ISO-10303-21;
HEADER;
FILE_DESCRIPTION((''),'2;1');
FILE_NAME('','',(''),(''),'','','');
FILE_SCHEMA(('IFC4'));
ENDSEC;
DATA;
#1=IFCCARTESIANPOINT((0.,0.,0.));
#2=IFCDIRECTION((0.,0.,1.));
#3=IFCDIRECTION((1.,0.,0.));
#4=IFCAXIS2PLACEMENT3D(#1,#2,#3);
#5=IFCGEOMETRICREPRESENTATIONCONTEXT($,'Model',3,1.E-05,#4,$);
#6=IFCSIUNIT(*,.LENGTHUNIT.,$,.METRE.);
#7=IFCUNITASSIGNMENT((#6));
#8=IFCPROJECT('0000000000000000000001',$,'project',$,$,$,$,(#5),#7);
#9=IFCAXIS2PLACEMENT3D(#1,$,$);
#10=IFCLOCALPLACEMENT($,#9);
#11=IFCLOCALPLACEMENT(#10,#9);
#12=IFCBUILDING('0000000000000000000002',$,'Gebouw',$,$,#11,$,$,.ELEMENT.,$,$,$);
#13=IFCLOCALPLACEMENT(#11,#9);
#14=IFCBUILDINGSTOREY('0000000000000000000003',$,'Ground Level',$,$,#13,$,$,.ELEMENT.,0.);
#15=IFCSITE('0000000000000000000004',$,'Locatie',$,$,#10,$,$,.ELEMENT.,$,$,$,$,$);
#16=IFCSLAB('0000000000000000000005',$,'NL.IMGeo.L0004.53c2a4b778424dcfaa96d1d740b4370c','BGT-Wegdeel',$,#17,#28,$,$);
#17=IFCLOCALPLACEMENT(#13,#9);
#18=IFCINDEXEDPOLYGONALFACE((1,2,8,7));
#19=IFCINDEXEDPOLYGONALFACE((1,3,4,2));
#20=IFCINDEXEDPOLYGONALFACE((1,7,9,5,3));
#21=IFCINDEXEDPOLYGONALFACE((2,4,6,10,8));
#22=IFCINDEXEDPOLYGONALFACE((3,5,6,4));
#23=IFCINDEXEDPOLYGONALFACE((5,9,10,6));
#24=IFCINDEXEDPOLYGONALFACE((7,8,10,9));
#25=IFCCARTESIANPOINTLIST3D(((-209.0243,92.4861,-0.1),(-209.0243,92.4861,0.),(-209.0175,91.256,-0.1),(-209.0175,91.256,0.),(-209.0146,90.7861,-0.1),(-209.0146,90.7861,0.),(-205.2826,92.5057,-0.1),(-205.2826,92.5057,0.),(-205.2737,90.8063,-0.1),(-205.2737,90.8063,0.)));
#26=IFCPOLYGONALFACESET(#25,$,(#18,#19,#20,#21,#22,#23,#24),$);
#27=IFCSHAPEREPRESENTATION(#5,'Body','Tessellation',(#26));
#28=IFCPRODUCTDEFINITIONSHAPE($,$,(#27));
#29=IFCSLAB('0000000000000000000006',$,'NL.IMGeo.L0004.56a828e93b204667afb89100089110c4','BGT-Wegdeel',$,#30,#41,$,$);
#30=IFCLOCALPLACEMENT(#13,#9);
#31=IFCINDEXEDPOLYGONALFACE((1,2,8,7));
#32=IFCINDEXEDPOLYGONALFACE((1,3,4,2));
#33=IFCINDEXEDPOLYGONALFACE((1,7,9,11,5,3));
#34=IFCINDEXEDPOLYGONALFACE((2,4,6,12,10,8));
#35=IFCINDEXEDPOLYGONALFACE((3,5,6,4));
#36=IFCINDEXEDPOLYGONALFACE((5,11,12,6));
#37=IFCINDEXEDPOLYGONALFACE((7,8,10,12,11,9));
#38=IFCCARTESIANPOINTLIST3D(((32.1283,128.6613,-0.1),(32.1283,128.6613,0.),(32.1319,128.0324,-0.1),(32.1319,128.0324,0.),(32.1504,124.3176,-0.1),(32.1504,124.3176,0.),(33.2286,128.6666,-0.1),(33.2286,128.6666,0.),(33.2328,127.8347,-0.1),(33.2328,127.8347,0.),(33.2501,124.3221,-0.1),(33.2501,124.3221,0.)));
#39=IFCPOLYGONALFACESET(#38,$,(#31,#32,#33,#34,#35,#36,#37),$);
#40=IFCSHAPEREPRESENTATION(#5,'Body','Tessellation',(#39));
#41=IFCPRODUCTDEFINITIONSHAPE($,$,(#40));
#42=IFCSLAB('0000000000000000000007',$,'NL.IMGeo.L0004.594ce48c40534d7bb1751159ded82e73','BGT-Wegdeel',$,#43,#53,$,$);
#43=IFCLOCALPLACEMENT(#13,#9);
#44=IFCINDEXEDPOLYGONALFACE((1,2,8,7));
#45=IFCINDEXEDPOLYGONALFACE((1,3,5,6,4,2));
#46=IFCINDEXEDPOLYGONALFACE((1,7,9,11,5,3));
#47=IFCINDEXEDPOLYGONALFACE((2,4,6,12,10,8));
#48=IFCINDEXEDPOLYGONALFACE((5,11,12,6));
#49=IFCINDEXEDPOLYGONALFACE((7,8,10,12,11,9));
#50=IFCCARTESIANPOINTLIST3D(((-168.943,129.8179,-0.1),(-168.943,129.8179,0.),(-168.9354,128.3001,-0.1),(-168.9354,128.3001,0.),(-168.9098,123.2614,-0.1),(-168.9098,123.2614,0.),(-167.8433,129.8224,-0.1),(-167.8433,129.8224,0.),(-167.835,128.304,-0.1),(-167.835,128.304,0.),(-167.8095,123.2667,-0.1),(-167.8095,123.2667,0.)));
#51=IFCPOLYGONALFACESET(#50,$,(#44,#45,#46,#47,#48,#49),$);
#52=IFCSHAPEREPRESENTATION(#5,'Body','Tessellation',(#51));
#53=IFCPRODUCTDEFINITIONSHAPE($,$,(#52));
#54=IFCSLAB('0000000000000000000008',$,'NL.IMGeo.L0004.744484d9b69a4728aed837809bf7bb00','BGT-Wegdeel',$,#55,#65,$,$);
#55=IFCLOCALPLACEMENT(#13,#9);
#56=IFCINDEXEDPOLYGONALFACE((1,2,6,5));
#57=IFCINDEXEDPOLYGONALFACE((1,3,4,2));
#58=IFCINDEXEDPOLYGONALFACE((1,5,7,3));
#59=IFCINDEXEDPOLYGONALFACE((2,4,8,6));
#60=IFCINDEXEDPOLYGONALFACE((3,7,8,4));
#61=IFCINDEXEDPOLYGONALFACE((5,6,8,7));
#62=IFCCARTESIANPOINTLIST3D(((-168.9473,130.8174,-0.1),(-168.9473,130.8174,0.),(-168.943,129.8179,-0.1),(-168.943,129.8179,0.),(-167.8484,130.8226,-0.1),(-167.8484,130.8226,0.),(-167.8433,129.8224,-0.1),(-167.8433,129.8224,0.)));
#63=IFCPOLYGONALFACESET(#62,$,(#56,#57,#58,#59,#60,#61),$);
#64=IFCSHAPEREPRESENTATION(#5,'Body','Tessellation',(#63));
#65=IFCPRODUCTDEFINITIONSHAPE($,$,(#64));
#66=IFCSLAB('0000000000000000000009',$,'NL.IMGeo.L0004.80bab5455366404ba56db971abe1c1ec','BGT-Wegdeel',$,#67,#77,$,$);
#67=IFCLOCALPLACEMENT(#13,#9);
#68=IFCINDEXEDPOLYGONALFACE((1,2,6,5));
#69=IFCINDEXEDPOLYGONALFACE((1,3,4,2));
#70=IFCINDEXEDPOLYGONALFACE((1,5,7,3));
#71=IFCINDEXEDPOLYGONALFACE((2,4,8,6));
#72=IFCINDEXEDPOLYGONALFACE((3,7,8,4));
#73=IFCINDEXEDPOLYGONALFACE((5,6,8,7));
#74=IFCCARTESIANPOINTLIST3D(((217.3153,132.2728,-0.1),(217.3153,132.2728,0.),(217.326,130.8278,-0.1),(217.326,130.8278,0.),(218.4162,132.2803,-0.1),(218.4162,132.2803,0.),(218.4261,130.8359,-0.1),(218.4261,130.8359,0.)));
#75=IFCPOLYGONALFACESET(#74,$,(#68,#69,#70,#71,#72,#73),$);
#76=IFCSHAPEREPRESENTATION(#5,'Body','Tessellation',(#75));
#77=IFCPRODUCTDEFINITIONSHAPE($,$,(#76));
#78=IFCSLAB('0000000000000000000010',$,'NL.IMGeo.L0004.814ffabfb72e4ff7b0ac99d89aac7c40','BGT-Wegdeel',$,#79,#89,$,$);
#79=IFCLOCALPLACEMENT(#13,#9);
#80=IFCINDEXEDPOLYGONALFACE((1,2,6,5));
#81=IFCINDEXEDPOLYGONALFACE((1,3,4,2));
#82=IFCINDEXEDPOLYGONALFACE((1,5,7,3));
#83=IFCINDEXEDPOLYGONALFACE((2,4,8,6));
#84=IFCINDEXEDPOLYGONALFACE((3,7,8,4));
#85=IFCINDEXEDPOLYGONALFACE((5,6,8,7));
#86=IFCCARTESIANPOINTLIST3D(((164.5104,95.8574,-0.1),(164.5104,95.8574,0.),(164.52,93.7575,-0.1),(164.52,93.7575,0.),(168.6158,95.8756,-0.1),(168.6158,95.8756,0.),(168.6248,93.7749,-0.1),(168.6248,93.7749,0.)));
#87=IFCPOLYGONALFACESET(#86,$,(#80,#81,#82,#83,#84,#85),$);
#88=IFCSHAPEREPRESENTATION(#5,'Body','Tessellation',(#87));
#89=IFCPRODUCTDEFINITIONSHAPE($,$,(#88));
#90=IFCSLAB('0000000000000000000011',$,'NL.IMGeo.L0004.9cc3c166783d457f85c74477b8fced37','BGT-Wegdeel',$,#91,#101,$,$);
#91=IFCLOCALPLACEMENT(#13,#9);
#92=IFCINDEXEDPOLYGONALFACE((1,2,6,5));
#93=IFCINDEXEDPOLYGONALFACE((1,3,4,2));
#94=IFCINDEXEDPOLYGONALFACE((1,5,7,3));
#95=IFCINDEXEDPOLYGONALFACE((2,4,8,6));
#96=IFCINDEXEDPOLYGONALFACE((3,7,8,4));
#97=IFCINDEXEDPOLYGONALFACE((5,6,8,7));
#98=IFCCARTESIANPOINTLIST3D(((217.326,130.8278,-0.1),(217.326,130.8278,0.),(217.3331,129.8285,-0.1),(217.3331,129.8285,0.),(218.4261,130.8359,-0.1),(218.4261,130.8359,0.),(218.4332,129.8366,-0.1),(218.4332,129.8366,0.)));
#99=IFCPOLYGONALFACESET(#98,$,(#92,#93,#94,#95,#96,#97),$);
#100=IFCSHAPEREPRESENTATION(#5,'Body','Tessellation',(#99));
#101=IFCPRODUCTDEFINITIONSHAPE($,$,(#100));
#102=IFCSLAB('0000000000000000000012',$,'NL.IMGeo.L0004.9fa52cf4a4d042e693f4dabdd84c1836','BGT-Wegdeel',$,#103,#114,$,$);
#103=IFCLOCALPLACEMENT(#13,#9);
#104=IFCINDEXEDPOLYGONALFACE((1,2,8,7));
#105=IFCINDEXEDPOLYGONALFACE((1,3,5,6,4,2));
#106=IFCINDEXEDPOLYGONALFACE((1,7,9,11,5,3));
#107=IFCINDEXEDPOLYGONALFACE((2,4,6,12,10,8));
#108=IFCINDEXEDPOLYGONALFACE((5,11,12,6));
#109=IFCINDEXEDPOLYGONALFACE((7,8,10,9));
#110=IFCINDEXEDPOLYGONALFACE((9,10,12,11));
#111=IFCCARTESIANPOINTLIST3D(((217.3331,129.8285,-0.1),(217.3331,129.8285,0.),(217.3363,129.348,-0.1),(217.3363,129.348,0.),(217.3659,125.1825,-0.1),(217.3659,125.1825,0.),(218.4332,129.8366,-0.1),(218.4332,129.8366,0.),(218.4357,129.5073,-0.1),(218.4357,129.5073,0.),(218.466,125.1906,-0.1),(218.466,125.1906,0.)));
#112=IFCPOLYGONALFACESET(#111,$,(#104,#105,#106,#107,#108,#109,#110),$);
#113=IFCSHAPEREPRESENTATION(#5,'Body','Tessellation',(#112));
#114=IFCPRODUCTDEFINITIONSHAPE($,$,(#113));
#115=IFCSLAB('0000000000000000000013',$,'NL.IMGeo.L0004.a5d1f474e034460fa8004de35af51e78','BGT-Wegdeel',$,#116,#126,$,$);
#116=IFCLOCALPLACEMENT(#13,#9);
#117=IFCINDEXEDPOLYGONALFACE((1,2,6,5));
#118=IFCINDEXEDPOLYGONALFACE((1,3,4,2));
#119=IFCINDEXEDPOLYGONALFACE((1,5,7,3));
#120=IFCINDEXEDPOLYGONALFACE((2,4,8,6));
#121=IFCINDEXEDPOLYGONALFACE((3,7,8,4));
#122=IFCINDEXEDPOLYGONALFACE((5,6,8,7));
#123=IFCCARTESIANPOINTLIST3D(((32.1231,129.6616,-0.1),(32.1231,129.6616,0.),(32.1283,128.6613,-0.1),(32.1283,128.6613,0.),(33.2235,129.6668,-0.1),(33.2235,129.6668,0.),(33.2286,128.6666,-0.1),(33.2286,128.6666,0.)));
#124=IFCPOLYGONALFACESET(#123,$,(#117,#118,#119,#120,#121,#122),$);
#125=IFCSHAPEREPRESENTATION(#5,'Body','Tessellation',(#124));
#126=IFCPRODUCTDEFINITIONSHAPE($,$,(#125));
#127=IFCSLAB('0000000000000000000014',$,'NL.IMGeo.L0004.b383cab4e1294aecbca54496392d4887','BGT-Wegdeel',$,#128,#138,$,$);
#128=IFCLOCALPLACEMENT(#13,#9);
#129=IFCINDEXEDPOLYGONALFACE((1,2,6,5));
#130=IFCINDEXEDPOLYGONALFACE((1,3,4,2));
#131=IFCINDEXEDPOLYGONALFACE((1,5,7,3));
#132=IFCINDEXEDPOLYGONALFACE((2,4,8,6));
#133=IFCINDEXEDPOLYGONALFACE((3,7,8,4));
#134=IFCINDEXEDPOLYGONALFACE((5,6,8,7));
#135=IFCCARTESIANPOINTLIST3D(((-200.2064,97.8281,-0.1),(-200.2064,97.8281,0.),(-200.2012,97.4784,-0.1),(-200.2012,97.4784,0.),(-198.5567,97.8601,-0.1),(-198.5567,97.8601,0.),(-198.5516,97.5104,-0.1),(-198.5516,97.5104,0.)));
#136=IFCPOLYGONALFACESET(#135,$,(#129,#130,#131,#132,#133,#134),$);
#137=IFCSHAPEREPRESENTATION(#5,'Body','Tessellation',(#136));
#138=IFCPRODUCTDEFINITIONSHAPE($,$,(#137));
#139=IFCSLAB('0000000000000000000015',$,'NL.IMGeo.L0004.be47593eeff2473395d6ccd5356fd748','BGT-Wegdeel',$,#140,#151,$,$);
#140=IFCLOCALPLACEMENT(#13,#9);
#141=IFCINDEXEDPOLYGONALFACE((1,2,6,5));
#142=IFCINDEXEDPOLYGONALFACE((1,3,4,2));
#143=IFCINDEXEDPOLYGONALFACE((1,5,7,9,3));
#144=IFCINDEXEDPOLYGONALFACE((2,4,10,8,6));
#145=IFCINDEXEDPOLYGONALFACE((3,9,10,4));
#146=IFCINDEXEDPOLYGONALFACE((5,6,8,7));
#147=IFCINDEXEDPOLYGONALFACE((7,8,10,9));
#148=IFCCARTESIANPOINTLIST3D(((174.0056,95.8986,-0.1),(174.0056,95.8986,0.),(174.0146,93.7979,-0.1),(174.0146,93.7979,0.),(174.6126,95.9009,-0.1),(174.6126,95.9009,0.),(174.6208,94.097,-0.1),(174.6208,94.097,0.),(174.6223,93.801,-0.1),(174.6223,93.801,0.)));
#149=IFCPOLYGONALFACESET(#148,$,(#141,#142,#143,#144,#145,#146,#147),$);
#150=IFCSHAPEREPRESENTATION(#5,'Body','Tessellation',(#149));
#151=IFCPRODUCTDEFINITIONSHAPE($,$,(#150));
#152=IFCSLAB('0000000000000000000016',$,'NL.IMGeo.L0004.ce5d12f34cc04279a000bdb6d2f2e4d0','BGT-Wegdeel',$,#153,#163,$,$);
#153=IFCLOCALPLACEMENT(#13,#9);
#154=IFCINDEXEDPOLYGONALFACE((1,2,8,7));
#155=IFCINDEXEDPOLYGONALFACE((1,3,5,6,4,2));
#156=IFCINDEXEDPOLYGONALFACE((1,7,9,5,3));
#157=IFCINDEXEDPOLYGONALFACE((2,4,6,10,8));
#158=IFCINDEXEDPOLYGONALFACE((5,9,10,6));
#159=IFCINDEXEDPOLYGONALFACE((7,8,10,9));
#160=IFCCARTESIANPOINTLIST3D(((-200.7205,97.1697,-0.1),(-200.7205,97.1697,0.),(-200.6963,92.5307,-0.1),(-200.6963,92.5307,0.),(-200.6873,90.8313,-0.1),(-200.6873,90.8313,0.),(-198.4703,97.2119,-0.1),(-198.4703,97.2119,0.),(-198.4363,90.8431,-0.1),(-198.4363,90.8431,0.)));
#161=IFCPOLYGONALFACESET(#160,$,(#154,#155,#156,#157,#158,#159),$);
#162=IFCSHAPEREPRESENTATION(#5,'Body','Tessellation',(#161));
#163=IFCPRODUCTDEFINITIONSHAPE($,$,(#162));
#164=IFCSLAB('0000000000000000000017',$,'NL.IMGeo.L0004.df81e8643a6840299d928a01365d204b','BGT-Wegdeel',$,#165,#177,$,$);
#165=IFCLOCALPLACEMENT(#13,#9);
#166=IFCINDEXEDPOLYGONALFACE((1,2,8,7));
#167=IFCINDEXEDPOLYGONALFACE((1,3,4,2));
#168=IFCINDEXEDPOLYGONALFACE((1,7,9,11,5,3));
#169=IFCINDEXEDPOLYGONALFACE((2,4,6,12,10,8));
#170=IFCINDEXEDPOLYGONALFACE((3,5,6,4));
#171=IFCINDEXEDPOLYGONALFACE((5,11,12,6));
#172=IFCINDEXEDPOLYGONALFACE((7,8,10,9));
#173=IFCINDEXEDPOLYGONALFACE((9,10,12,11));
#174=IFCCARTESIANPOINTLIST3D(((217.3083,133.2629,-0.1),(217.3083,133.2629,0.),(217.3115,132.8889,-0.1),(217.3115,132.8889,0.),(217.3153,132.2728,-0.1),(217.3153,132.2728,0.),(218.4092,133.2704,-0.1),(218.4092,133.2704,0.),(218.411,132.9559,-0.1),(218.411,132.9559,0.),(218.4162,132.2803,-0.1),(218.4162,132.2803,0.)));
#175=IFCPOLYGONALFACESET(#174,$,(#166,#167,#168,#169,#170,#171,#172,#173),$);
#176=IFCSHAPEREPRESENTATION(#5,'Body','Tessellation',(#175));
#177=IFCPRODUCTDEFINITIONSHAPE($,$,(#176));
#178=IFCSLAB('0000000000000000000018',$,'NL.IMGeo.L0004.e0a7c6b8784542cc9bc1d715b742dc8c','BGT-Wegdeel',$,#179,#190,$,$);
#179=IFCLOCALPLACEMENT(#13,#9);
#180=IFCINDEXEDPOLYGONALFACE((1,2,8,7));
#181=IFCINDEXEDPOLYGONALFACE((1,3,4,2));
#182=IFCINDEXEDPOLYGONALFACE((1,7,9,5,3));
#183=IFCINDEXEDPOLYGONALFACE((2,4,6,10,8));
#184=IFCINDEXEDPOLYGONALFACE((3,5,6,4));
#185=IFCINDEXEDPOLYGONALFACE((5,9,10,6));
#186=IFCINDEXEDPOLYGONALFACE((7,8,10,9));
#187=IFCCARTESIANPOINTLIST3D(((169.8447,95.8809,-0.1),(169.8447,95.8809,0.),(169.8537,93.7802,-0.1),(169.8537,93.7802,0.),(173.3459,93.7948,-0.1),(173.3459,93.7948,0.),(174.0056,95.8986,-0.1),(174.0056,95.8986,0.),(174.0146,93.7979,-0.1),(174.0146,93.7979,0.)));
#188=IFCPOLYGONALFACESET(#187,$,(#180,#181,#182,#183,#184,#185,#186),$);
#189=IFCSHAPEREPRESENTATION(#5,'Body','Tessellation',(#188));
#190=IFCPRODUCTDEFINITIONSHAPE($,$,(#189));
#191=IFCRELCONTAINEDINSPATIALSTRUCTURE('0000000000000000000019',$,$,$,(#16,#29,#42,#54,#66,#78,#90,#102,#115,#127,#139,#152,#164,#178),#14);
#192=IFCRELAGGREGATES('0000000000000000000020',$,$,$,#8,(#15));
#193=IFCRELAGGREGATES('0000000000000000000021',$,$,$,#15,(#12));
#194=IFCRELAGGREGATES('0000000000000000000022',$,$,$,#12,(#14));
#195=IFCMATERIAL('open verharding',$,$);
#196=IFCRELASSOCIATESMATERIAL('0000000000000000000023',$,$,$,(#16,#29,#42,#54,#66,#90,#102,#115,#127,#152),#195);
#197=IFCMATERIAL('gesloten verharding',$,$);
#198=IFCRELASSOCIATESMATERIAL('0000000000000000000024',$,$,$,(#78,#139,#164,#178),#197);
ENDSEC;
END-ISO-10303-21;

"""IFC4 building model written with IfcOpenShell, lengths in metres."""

from ifc_helpers import new_model, si_unit, frame, origin, origin_with_axes, place, context, project, spatial, polyline, outline, extrude, material, element, save


model = new_model("IFC4")

# Units and contexts
model_context = context("Model", 3, precision=1e-05, world=origin_with_axes())
ifc_project = project(units=[si_unit("LENGTHUNIT", "METRE")], contexts=[model_context])

# Site, building, storey
site_placement = place(None, origin())
site = spatial("IfcSite", under=ifc_project, at=site_placement, Name="Locatie", CompositionType="ELEMENT")
building_placement = place(site_placement, origin())
building = spatial("IfcBuilding", under=site, at=building_placement, Name="Gebouw", CompositionType="ELEMENT")
storey_placement = place(building_placement, origin())
storey = spatial("IfcBuildingStorey", under=building, at=storey_placement, Name="Ground Level", CompositionType="ELEMENT", Elevation=0.0)

# Slabs
ifc_material_1 = material(Name="open verharding")
slab_1_placement = place(storey_placement, origin())
element("IfcSlab", 1, at=slab_1_placement, inside=storey, material=ifc_material_1, Name="NL.IMGeo.L0004.53c2a4b778424dcfaa96d1d740b4370c", Description="BGT-Wegdeel", context=model_context, shape_type="SweptSolid", body=[
    extrude(outline(polyline([(-209.0175, 91.256), (-209.0243, 92.4861), (-205.2826, 92.5057), (-205.2737, 90.8063), (-209.0146, 90.7861), (-209.0175, 91.256)])), frame((0.0, 0.0, -0.1), z_axis=(0.0, 0.0, 1.0), x_axis=(1.0, 0.0, 0.0)), (0.0, 0.0, 1.0), 0.1),
])
slab_2_placement = place(storey_placement, origin())
element("IfcSlab", 2, at=slab_2_placement, inside=storey, material=ifc_material_1, Name="NL.IMGeo.L0004.56a828e93b204667afb89100089110c4", Description="BGT-Wegdeel", context=model_context, shape_type="SweptSolid", body=[
    extrude(outline(polyline([(32.1504, 124.3176), (32.1319, 128.0324), (32.1283, 128.6613), (33.2286, 128.6666), (33.2328, 127.8347), (33.2501, 124.3221), (32.1504, 124.3176)])), frame((0.0, 0.0, -0.1), z_axis=(0.0, 0.0, 1.0), x_axis=(1.0, 0.0, 0.0)), (0.0, 0.0, 1.0), 0.1),
])
slab_3_placement = place(storey_placement, origin())
element("IfcSlab", 3, at=slab_3_placement, inside=storey, material=ifc_material_1, Name="NL.IMGeo.L0004.594ce48c40534d7bb1751159ded82e73", Description="BGT-Wegdeel", context=model_context, shape_type="SweptSolid", body=[
    extrude(outline(polyline([(-167.8433, 129.8224), (-167.835, 128.304), (-167.8095, 123.2667), (-168.9098, 123.2614), (-168.9354, 128.3001), (-168.943, 129.8179), (-167.8433, 129.8224)])), frame((0.0, 0.0, -0.1), z_axis=(0.0, 0.0, 1.0), x_axis=(1.0, 0.0, 0.0)), (0.0, 0.0, 1.0), 0.1),
])
slab_4_placement = place(storey_placement, origin())
element("IfcSlab", 4, at=slab_4_placement, inside=storey, material=ifc_material_1, Name="NL.IMGeo.L0004.744484d9b69a4728aed837809bf7bb00", Description="BGT-Wegdeel", context=model_context, shape_type="SweptSolid", body=[
    extrude(outline(polyline([(-168.9473, 130.8174), (-167.8484, 130.8226), (-167.8433, 129.8224), (-168.943, 129.8179), (-168.9473, 130.8174)])), frame((0.0, 0.0, -0.1), z_axis=(0.0, 0.0, 1.0), x_axis=(1.0, 0.0, 0.0)), (0.0, 0.0, 1.0), 0.1),
])
slab_5_placement = place(storey_placement, origin())
element("IfcSlab", 5, at=slab_5_placement, inside=storey, material=ifc_material_1, Name="NL.IMGeo.L0004.80bab5455366404ba56db971abe1c1ec", Description="BGT-Wegdeel", context=model_context, shape_type="SweptSolid", body=[
    extrude(outline(polyline([(217.326, 130.8278), (217.3153, 132.2728), (218.4162, 132.2803), (218.4261, 130.8359), (217.326, 130.8278)])), frame((0.0, 0.0, -0.1), z_axis=(0.0, 0.0, 1.0), x_axis=(1.0, 0.0, 0.0)), (0.0, 0.0, 1.0), 0.1),
])
ifc_material_2 = material(Name="gesloten verharding")
slab_6_placement = place(storey_placement, origin())
element("IfcSlab", 6, at=slab_6_placement, inside=storey, material=ifc_material_2, Name="NL.IMGeo.L0004.814ffabfb72e4ff7b0ac99d89aac7c40", Description="BGT-Wegdeel", context=model_context, shape_type="SweptSolid", body=[
    extrude(outline(polyline([(164.5104, 95.8574), (168.6158, 95.8756), (168.6248, 93.7749), (164.52, 93.7575), (164.5104, 95.8574)])), frame((0.0, 0.0, -0.1), z_axis=(0.0, 0.0, 1.0), x_axis=(1.0, 0.0, 0.0)), (0.0, 0.0, 1.0), 0.1),
])
slab_7_placement = place(storey_placement, origin())
element("IfcSlab", 7, at=slab_7_placement, inside=storey, material=ifc_material_1, Name="NL.IMGeo.L0004.9cc3c166783d457f85c74477b8fced37", Description="BGT-Wegdeel", context=model_context, shape_type="SweptSolid", body=[
    extrude(outline(polyline([(218.4332, 129.8366), (217.3331, 129.8285), (217.326, 130.8278), (218.4261, 130.8359), (218.4332, 129.8366)])), frame((0.0, 0.0, -0.1), z_axis=(0.0, 0.0, 1.0), x_axis=(1.0, 0.0, 0.0)), (0.0, 0.0, 1.0), 0.1),
])
slab_8_placement = place(storey_placement, origin())
element("IfcSlab", 8, at=slab_8_placement, inside=storey, material=ifc_material_1, Name="NL.IMGeo.L0004.9fa52cf4a4d042e693f4dabdd84c1836", Description="BGT-Wegdeel", context=model_context, shape_type="SweptSolid", body=[
    extrude(outline(polyline([(217.3659, 125.1825), (217.3363, 129.348), (217.3331, 129.8285), (218.4332, 129.8366), (218.4357, 129.5073), (218.466, 125.1906), (217.3659, 125.1825)])), frame((0.0, 0.0, -0.1), z_axis=(0.0, 0.0, 1.0), x_axis=(1.0, 0.0, 0.0)), (0.0, 0.0, 1.0), 0.1),
])
slab_9_placement = place(storey_placement, origin())
element("IfcSlab", 9, at=slab_9_placement, inside=storey, material=ifc_material_1, Name="NL.IMGeo.L0004.a5d1f474e034460fa8004de35af51e78", Description="BGT-Wegdeel", context=model_context, shape_type="SweptSolid", body=[
    extrude(outline(polyline([(33.2235, 129.6668), (33.2286, 128.6666), (32.1283, 128.6613), (32.1231, 129.6616), (33.2235, 129.6668)])), frame((0.0, 0.0, -0.1), z_axis=(0.0, 0.0, 1.0), x_axis=(1.0, 0.0, 0.0)), (0.0, 0.0, 1.0), 0.1),
])
slab_10_placement = place(storey_placement, origin())
element("IfcSlab", 10, at=slab_10_placement, inside=storey, material=ifc_material_1, Name="NL.IMGeo.L0004.b383cab4e1294aecbca54496392d4887", Description="BGT-Wegdeel", context=model_context, shape_type="SweptSolid", body=[
    extrude(outline(polyline([(-200.2064, 97.8281), (-198.5567, 97.8601), (-198.5516, 97.5104), (-200.2012, 97.4784), (-200.2064, 97.8281)])), frame((0.0, 0.0, -0.1), z_axis=(0.0, 0.0, 1.0), x_axis=(1.0, 0.0, 0.0)), (0.0, 0.0, 1.0), 0.1),
])
slab_11_placement = place(storey_placement, origin())
element("IfcSlab", 11, at=slab_11_placement, inside=storey, material=ifc_material_2, Name="NL.IMGeo.L0004.be47593eeff2473395d6ccd5356fd748", Description="BGT-Wegdeel", context=model_context, shape_type="SweptSolid", body=[
    extrude(outline(polyline([(174.0056, 95.8986), (174.6126, 95.9009), (174.6208, 94.097), (174.6223, 93.801), (174.0146, 93.7979), (174.0056, 95.8986)])), frame((0.0, 0.0, -0.1), z_axis=(0.0, 0.0, 1.0), x_axis=(1.0, 0.0, 0.0)), (0.0, 0.0, 1.0), 0.1),
])
slab_12_placement = place(storey_placement, origin())
element("IfcSlab", 12, at=slab_12_placement, inside=storey, material=ifc_material_1, Name="NL.IMGeo.L0004.ce5d12f34cc04279a000bdb6d2f2e4d0", Description="BGT-Wegdeel", context=model_context, shape_type="SweptSolid", body=[
    extrude(outline(polyline([(-200.6963, 92.5307), (-200.7205, 97.1697), (-198.4703, 97.2119), (-198.4363, 90.8431), (-200.6873, 90.8313), (-200.6963, 92.5307)])), frame((0.0, 0.0, -0.1), z_axis=(0.0, 0.0, 1.0), x_axis=(1.0, 0.0, 0.0)), (0.0, 0.0, 1.0), 0.1),
])
slab_13_placement = place(storey_placement, origin())
element("IfcSlab", 13, at=slab_13_placement, inside=storey, material=ifc_material_2, Name="NL.IMGeo.L0004.df81e8643a6840299d928a01365d204b", Description="BGT-Wegdeel", context=model_context, shape_type="SweptSolid", body=[
    extrude(outline(polyline([(217.3115, 132.8889), (217.3083, 133.2629), (218.4092, 133.2704), (218.411, 132.9559), (218.4162, 132.2803), (217.3153, 132.2728), (217.3115, 132.8889)])), frame((0.0, 0.0, -0.1), z_axis=(0.0, 0.0, 1.0), x_axis=(1.0, 0.0, 0.0)), (0.0, 0.0, 1.0), 0.1),
])
slab_14_placement = place(storey_placement, origin())
element("IfcSlab", 14, at=slab_14_placement, inside=storey, material=ifc_material_2, Name="NL.IMGeo.L0004.e0a7c6b8784542cc9bc1d715b742dc8c", Description="BGT-Wegdeel", context=model_context, shape_type="SweptSolid", body=[
    extrude(outline(polyline([(169.8447, 95.8809), (174.0056, 95.8986), (174.0146, 93.7979), (173.3459, 93.7948), (169.8537, 93.7802), (169.8447, 95.8809)])), frame((0.0, 0.0, -0.1), z_axis=(0.0, 0.0, 1.0), x_axis=(1.0, 0.0, 0.0)), (0.0, 0.0, 1.0), 0.1),
])

save(model, "model.ifc")
